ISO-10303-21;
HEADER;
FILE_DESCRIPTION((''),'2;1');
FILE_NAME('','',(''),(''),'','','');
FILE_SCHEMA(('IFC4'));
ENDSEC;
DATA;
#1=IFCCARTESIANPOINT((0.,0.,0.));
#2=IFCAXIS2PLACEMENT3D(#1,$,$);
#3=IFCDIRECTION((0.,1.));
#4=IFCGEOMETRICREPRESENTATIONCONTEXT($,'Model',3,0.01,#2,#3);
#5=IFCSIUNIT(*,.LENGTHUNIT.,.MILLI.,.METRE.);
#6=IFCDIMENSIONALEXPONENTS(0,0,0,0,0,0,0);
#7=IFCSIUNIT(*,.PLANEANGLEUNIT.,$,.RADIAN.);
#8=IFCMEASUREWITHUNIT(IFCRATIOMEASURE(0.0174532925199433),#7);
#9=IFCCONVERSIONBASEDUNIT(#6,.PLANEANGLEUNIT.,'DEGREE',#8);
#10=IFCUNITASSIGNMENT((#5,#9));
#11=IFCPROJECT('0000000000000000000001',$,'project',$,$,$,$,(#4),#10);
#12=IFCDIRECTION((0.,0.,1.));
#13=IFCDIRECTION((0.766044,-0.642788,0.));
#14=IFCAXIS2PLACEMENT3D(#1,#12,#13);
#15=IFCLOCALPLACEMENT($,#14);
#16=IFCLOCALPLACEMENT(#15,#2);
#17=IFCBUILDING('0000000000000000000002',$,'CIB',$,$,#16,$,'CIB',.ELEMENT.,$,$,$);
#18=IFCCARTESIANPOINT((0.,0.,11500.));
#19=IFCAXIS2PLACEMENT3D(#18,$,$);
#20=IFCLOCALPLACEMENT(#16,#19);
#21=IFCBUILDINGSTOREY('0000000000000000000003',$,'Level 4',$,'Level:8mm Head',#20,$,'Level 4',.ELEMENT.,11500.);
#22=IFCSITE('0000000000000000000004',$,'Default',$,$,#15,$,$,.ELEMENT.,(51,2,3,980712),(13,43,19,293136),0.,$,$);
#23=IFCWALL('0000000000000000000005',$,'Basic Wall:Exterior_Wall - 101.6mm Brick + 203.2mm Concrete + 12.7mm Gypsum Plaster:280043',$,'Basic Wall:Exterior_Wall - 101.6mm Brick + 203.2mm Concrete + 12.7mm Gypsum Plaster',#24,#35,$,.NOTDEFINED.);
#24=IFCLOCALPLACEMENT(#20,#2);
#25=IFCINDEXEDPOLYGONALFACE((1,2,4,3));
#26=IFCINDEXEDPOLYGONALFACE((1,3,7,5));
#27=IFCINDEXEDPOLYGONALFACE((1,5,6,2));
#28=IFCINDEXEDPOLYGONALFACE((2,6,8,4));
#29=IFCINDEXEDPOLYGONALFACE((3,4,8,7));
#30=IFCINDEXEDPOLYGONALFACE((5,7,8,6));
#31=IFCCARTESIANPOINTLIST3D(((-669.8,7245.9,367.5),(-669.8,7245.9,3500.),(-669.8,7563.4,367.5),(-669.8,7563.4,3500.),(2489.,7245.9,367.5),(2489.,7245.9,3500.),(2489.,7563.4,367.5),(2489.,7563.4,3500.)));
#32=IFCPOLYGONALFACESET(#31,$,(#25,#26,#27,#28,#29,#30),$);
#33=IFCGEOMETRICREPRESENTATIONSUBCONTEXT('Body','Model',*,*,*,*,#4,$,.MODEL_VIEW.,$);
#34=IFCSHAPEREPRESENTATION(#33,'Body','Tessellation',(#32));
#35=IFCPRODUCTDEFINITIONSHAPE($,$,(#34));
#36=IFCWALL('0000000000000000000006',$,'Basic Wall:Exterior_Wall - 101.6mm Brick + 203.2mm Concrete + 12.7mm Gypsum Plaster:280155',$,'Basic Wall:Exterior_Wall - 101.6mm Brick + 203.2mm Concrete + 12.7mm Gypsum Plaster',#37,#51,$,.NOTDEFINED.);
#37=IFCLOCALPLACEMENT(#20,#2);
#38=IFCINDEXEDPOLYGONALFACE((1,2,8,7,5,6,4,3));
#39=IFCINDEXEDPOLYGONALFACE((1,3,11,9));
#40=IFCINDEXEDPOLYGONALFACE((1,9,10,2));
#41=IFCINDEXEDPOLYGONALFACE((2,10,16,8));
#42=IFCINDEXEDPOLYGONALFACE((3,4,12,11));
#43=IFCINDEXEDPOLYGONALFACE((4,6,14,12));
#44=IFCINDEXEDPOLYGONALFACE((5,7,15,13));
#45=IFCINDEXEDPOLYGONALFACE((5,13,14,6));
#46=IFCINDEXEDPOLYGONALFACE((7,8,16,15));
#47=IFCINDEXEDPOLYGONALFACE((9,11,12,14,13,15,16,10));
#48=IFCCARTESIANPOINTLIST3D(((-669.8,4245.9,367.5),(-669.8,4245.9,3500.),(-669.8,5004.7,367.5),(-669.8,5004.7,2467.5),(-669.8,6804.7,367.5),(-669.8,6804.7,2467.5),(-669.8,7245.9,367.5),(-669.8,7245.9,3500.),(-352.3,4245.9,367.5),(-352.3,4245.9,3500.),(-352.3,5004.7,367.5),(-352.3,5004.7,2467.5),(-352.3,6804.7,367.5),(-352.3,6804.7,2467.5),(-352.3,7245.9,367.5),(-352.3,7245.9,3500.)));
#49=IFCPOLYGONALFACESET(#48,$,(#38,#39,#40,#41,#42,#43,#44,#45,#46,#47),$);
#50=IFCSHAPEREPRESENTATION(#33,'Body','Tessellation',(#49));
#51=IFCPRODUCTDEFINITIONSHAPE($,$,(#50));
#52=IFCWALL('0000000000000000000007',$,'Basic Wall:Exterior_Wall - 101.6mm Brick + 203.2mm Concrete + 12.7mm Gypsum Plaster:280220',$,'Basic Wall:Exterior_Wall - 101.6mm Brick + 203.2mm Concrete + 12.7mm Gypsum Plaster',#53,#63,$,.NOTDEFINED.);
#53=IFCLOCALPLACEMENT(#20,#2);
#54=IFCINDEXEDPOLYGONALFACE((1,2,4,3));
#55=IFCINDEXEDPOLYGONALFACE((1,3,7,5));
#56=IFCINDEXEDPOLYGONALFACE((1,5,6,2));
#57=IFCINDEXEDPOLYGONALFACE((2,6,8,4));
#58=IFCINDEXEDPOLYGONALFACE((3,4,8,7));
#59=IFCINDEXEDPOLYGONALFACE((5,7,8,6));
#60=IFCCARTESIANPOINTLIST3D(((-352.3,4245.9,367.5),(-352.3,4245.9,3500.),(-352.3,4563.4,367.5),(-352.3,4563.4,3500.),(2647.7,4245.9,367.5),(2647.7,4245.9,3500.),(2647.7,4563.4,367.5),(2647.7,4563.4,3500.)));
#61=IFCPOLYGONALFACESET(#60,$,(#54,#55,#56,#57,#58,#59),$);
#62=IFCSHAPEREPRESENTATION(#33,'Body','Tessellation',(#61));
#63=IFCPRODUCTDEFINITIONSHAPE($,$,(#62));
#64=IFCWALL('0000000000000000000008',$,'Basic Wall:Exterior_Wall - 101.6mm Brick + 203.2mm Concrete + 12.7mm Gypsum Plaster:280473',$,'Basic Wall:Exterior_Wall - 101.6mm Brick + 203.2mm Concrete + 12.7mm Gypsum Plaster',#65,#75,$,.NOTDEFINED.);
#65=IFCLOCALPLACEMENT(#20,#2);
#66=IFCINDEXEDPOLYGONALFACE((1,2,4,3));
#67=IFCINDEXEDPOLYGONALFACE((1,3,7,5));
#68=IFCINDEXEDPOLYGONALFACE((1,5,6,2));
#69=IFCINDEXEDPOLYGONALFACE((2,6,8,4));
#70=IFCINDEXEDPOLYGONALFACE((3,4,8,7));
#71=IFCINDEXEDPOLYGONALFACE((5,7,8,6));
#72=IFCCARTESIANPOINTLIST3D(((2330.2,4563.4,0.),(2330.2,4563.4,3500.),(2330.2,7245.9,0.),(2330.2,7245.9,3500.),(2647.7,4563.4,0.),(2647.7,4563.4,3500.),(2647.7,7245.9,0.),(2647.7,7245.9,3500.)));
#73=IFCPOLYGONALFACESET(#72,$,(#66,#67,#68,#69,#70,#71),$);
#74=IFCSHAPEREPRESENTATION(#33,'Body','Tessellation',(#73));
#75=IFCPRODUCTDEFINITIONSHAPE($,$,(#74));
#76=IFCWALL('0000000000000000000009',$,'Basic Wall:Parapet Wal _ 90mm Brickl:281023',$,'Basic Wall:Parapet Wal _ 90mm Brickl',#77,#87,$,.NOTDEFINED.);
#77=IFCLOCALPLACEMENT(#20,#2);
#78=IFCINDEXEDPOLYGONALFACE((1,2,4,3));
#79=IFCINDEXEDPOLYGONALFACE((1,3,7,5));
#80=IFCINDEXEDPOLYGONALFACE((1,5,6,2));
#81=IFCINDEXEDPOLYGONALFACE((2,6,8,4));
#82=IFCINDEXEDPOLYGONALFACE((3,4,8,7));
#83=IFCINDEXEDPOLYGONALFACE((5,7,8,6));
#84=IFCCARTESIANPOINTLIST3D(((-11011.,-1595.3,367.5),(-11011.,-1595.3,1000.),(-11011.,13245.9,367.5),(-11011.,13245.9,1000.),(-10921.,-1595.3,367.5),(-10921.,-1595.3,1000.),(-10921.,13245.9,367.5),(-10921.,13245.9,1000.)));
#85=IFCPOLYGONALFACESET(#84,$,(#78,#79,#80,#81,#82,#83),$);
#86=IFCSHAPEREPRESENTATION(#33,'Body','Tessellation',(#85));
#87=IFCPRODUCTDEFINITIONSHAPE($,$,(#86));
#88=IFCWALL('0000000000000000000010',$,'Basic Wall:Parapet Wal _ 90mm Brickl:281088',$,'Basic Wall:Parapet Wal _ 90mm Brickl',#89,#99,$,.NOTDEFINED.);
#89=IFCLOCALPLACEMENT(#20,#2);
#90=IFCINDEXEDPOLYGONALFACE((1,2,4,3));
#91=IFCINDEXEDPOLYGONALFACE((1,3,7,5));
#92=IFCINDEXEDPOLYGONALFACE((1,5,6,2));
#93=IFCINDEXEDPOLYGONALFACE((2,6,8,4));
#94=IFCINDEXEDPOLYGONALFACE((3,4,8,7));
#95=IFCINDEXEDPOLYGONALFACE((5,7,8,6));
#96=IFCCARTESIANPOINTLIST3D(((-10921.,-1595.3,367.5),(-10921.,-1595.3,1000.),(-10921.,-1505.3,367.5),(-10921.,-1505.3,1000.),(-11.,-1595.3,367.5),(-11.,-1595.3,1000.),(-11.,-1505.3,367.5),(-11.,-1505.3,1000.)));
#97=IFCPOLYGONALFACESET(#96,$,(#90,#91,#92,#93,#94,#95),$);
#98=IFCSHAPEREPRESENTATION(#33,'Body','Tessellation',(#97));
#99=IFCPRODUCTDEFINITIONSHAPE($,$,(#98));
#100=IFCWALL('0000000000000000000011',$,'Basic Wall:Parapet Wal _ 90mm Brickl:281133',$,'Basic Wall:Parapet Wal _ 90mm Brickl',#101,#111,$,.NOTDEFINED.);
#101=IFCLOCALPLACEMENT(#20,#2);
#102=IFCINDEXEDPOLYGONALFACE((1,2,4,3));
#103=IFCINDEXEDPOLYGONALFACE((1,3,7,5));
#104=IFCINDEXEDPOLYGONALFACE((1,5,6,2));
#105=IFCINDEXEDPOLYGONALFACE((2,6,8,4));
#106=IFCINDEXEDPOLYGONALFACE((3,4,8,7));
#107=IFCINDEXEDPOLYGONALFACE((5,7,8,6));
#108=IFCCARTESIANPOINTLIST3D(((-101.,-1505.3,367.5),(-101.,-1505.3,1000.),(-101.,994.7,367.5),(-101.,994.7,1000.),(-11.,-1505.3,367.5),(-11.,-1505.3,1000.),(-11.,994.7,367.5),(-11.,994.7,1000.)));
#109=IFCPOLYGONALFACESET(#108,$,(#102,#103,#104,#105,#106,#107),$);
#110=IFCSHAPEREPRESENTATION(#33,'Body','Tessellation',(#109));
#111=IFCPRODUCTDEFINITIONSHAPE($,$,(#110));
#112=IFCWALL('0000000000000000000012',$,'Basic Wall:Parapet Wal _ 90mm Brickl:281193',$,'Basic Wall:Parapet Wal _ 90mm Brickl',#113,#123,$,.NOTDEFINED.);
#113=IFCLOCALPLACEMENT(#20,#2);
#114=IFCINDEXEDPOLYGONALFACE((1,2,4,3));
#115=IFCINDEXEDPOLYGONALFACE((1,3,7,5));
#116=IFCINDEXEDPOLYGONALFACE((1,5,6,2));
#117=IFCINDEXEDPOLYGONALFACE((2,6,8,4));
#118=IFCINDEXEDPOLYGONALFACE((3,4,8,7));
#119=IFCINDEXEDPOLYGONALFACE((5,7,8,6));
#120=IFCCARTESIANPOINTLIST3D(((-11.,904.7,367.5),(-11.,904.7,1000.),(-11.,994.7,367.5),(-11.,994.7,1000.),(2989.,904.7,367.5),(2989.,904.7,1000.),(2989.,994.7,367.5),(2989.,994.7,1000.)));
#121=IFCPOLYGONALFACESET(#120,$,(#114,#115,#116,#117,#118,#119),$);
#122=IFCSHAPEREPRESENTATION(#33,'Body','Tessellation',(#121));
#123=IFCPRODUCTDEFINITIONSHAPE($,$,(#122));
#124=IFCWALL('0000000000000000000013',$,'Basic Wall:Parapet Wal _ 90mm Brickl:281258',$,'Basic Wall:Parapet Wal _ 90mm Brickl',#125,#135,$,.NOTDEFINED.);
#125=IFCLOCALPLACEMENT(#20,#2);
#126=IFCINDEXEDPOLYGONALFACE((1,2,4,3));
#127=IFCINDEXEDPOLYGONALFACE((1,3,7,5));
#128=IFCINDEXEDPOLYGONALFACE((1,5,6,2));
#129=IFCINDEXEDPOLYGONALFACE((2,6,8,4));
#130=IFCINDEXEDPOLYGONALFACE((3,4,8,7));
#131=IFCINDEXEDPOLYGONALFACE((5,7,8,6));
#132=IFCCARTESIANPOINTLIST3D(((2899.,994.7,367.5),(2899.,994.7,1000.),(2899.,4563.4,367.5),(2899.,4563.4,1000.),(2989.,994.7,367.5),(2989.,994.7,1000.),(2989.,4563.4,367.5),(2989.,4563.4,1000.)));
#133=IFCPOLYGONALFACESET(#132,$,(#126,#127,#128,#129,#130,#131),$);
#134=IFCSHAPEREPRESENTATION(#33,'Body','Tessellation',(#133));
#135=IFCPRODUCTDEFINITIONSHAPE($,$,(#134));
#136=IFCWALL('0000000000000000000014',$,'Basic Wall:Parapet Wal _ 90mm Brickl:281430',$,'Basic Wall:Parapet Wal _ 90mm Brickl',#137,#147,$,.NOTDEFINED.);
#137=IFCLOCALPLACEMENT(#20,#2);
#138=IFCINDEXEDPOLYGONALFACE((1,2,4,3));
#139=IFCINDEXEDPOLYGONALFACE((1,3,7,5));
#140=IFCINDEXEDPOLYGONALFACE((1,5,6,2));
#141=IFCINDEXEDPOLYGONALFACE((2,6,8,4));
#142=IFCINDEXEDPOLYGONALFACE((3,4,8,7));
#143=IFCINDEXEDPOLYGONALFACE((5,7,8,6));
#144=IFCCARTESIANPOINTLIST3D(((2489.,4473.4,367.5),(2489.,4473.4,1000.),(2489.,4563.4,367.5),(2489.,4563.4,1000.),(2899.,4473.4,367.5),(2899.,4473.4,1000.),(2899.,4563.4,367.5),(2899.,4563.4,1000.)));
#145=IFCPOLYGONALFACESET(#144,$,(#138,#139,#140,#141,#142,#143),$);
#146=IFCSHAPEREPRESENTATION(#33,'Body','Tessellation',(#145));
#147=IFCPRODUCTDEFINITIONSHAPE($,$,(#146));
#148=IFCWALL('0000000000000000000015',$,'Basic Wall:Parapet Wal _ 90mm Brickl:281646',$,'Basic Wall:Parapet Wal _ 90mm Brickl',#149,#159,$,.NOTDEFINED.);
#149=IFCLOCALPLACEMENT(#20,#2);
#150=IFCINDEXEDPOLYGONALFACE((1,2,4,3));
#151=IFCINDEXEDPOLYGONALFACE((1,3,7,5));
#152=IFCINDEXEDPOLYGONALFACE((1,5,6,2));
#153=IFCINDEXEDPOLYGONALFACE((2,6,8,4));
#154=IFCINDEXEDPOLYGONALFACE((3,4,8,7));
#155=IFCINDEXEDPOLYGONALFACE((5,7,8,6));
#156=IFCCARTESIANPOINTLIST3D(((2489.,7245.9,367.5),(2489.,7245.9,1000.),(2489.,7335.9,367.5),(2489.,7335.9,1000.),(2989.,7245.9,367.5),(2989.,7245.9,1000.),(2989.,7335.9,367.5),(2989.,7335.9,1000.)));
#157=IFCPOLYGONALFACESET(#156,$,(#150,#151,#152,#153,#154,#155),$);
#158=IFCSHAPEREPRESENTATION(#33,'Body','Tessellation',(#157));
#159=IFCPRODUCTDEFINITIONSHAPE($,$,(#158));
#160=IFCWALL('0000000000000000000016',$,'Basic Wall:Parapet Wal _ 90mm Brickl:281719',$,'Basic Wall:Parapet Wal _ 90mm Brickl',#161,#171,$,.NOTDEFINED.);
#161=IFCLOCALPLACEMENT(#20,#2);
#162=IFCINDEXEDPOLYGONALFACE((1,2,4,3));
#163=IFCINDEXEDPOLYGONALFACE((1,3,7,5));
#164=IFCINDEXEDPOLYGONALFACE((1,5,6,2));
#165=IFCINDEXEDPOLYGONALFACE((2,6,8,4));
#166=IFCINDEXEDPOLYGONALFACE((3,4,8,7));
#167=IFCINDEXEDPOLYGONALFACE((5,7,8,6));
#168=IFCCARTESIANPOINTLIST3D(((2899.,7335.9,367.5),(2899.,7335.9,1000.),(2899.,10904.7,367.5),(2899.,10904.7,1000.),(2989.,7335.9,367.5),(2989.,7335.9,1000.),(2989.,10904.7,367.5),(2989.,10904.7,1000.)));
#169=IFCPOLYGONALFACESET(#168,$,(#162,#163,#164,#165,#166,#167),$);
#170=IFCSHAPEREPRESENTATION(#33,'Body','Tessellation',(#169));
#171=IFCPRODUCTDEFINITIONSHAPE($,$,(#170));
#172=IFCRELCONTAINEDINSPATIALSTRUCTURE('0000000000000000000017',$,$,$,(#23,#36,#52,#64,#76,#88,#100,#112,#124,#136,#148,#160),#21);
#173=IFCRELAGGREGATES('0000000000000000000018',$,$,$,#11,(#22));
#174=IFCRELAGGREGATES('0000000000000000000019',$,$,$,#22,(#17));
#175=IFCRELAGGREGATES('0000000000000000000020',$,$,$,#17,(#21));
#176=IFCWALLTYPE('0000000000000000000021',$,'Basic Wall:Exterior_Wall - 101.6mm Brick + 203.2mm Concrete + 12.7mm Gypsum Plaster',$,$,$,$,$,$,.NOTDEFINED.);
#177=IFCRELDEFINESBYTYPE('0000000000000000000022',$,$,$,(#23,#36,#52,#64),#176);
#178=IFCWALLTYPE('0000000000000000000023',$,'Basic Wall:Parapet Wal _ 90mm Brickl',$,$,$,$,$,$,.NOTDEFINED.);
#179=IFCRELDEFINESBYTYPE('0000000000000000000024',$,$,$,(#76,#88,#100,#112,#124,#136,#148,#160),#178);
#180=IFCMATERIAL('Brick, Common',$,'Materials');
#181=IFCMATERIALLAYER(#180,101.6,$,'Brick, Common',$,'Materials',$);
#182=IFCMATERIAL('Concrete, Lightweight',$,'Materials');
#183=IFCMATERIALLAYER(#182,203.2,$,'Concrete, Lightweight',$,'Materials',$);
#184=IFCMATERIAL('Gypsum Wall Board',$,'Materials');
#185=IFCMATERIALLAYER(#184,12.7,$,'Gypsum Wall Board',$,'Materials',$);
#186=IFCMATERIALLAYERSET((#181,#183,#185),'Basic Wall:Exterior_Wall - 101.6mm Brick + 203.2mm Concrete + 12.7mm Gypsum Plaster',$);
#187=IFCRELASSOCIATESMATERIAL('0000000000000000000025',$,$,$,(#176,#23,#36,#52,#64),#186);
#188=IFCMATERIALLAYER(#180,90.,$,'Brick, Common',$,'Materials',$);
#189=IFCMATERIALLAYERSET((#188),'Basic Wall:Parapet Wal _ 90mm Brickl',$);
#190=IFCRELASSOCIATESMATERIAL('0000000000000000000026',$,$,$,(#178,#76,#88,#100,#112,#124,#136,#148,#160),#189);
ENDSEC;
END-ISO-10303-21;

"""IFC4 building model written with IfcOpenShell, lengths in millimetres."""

from ifc_helpers import new_model, entity, si_unit, converted_unit, direction, frame, frame_2d, origin, place, context, subcontext, project, spatial, rectangle, extrude, material, layer, layer_set, layer_usage, type_object, element, save


model = new_model("IFC4")

# Units and contexts
model_context = context("Model", 3, precision=0.01, world=origin(), true_north=direction((0.0, 1.0)))
body_context = subcontext(model_context, "Body", "Model", "MODEL_VIEW")
ifc_project = project(units=[si_unit("LENGTHUNIT", "METRE", prefix="MILLI"), converted_unit("PLANEANGLEUNIT", "DEGREE", entity("IfcRatioMeasure", 0.0174532925199433), si_unit("PLANEANGLEUNIT", "RADIAN"), dimensions=[0, 0, 0, 0, 0, 0, 0])], contexts=[model_context])

# Site, building, storey
site_placement = place(None, frame((0.0, 0.0, 0.0), z_axis=(0.0, 0.0, 1.0), x_axis=(0.766044, -0.642788, 0.0)))
site = spatial("IfcSite", under=ifc_project, at=site_placement, Name="Default", CompositionType="ELEMENT", RefLatitude=(51, 2, 3, 980712), RefLongitude=(13, 43, 19, 293136), RefElevation=0.0)
building_placement = place(site_placement, origin())
building = spatial("IfcBuilding", under=site, at=building_placement, Name="CIB", LongName="CIB", CompositionType="ELEMENT")
storey_placement = place(building_placement, frame((0.0, 0.0, 11500.0)))
storey = spatial("IfcBuildingStorey", under=building, at=storey_placement, Name="Level 4", ObjectType="Level:8mm Head", LongName="Level 4", CompositionType="ELEMENT", Elevation=11500.0)

# Wall
ifc_material_1 = material(Name="Brick, Common", Category="Materials")
ifc_layer_1 = layer(ifc_material_1, 101.6, Name="Brick, Common", Category="Materials")
ifc_material_2 = material(Name="Concrete, Lightweight", Category="Materials")
ifc_layer_2 = layer(ifc_material_2, 203.2, Name="Concrete, Lightweight", Category="Materials")
ifc_material_3 = material(Name="Gypsum Wall Board", Category="Materials")
ifc_layer_3 = layer(ifc_material_3, 12.7, Name="Gypsum Wall Board", Category="Materials")
ifc_layer_set_1 = layer_set([ifc_layer_1, ifc_layer_2, ifc_layer_3], Name="Basic Wall:Exterior_Wall - 101.6mm Brick + 203.2mm Concrete + 12.7mm Gypsum Plaster")
ifc_layer_usage_1 = layer_usage(ifc_layer_set_1, "AXIS2", "NEGATIVE", 158.8)
wall_type_1 = type_object("IfcWallType", Name="Basic Wall:Exterior_Wall - 101.6mm Brick + 203.2mm Concrete + 12.7mm Gypsum Plaster", PredefinedType="NOTDEFINED", material=ifc_layer_set_1)
wall_1_placement = place(storey_placement, frame((2647.7, 7404.7, 367.5), z_axis=(0.0, 0.0, 1.0), x_axis=(-1.0, 0.0, 0.0)))
element("IfcWall", 1, at=wall_1_placement, inside=storey, type_object=wall_type_1, material=ifc_layer_usage_1, Name="Basic Wall:Exterior_Wall - 101.6mm Brick + 203.2mm Concrete + 12.7mm Gypsum Plaster:280043", ObjectType="Basic Wall:Exterior_Wall - 101.6mm Brick + 203.2mm Concrete + 12.7mm Gypsum Plaster", PredefinedType="NOTDEFINED", context=body_context, shape_type="SweptSolid", body=[
    extrude(rectangle(XDim=3158.8, YDim=317.5, at=frame_2d((1738.1, 0.0), x_axis=(-1.0, 0.0))), origin(), (0.0, 0.0, 1.0), 3132.5),
])

# Wall, opening
ifc_layer_usage_2 = layer_usage(ifc_layer_set_1, "AXIS2", "NEGATIVE", 158.8)
wall_2_placement = place(storey_placement, frame((-511.0, 7245.9, 367.5), z_axis=(0.0, 0.0, 1.0), x_axis=(0.0, -1.0, 0.0)))
wall_2 = element("IfcWall", 2, at=wall_2_placement, inside=storey, type_object=wall_type_1, material=ifc_layer_usage_2, Name="Basic Wall:Exterior_Wall - 101.6mm Brick + 203.2mm Concrete + 12.7mm Gypsum Plaster:280155", ObjectType="Basic Wall:Exterior_Wall - 101.6mm Brick + 203.2mm Concrete + 12.7mm Gypsum Plaster", PredefinedType="NOTDEFINED", context=body_context, shape_type="SweptSolid", body=[
    extrude(rectangle(XDim=3000.0, YDim=317.5, at=frame_2d((1500.0, 0.0), x_axis=(-1.0, 0.0))), origin(), (0.0, 0.0, 1.0), 3132.5),
])
opening_placement = place(wall_2_placement, frame((2241.2, 158.7, 0.0)))
element("IfcOpeningElement", 3, at=opening_placement, cuts=wall_2, ObjectType="Opening", PredefinedType="OPENING", context=body_context, shape_type="SweptSolid", body=[
    extrude(rectangle(XDim=2100.0, YDim=1800.0, at=frame_2d((1050.0, 900.0), x_axis=(1.0, 0.0))), frame((0.0, 0.0, 0.0), z_axis=(0.0, -1.0, 0.0), x_axis=(0.0, 0.0, 1.0)), (0.0, 0.0, 1.0), 317.5),
])

# Walls
ifc_layer_usage_3 = layer_usage(ifc_layer_set_1, "AXIS2", "NEGATIVE", 158.8)
wall_3_placement = place(storey_placement, frame((-352.3, 4404.7, 367.5)))
element("IfcWall", 4, at=wall_3_placement, inside=storey, type_object=wall_type_1, material=ifc_layer_usage_3, Name="Basic Wall:Exterior_Wall - 101.6mm Brick + 203.2mm Concrete + 12.7mm Gypsum Plaster:280220", ObjectType="Basic Wall:Exterior_Wall - 101.6mm Brick + 203.2mm Concrete + 12.7mm Gypsum Plaster", PredefinedType="NOTDEFINED", context=body_context, shape_type="SweptSolid", body=[
    extrude(rectangle(XDim=3000.0, YDim=317.5, at=frame_2d((1500.0, 0.0), x_axis=(-1.0, 0.0))), origin(), (0.0, 0.0, 1.0), 3132.5),
])
ifc_layer_usage_4 = layer_usage(ifc_layer_set_1, "AXIS2", "NEGATIVE", 158.8)
wall_4_placement = place(storey_placement, frame((2489.0, 7245.9, 0.0), z_axis=(0.0, 0.0, 1.0), x_axis=(0.0, -1.0, 0.0)))
element("IfcWall", 5, at=wall_4_placement, inside=storey, type_object=wall_type_1, material=ifc_layer_usage_4, Name="Basic Wall:Exterior_Wall - 101.6mm Brick + 203.2mm Concrete + 12.7mm Gypsum Plaster:280473", ObjectType="Basic Wall:Exterior_Wall - 101.6mm Brick + 203.2mm Concrete + 12.7mm Gypsum Plaster", PredefinedType="NOTDEFINED", context=body_context, shape_type="SweptSolid", body=[
    extrude(rectangle(XDim=2682.5, YDim=317.5, at=frame_2d((1341.2, 0.0), x_axis=(-1.0, 0.0))), origin(), (0.0, 0.0, 1.0), 3500.0),
])
ifc_layer_4 = layer(ifc_material_1, 90.0, Name="Brick, Common", Category="Materials")
ifc_layer_set_2 = layer_set([ifc_layer_4], Name="Basic Wall:Parapet Wal _ 90mm Brickl")
ifc_layer_usage_5 = layer_usage(ifc_layer_set_2, "AXIS2", "NEGATIVE", 45.0)
wall_type_2 = type_object("IfcWallType", Name="Basic Wall:Parapet Wal _ 90mm Brickl", PredefinedType="NOTDEFINED", material=ifc_layer_set_2)
wall_5_placement = place(storey_placement, frame((-10966.0, 13245.9, 367.5), z_axis=(0.0, 0.0, 1.0), x_axis=(0.0, -1.0, 0.0)))
element("IfcWall", 6, at=wall_5_placement, inside=storey, type_object=wall_type_2, material=ifc_layer_usage_5, Name="Basic Wall:Parapet Wal _ 90mm Brickl:281023", ObjectType="Basic Wall:Parapet Wal _ 90mm Brickl", PredefinedType="NOTDEFINED", context=body_context, shape_type="SweptSolid", body=[
    extrude(rectangle(XDim=14841.2, YDim=90.0, at=frame_2d((7420.6, 0.0), x_axis=(-1.0, 0.0))), origin(), (0.0, 0.0, 1.0), 632.5),
])
ifc_layer_usage_6 = layer_usage(ifc_layer_set_2, "AXIS2", "NEGATIVE", 45.0)
wall_6_placement = place(storey_placement, frame((-10921.0, -1550.3, 367.5)))
element("IfcWall", 7, at=wall_6_placement, inside=storey, type_object=wall_type_2, material=ifc_layer_usage_6, Name="Basic Wall:Parapet Wal _ 90mm Brickl:281088", ObjectType="Basic Wall:Parapet Wal _ 90mm Brickl", PredefinedType="NOTDEFINED", context=body_context, shape_type="SweptSolid", body=[
    extrude(rectangle(XDim=10910.0, YDim=90.0, at=frame_2d((5455.0, 0.0), x_axis=(-1.0, 0.0))), origin(), (0.0, 0.0, 1.0), 632.5),
])
ifc_layer_usage_7 = layer_usage(ifc_layer_set_2, "AXIS2", "NEGATIVE", 45.0)
wall_7_placement = place(storey_placement, frame((-56.0, -1505.3, 367.5), z_axis=(0.0, 0.0, 1.0), x_axis=(0.0, 1.0, 0.0)))
element("IfcWall", 8, at=wall_7_placement, inside=storey, type_object=wall_type_2, material=ifc_layer_usage_7, Name="Basic Wall:Parapet Wal _ 90mm Brickl:281133", ObjectType="Basic Wall:Parapet Wal _ 90mm Brickl", PredefinedType="NOTDEFINED", context=body_context, shape_type="SweptSolid", body=[
    extrude(rectangle(XDim=2500.0, YDim=90.0, at=frame_2d((1250.0, 0.0), x_axis=(-1.0, 0.0))), origin(), (0.0, 0.0, 1.0), 632.5),
])
ifc_layer_usage_8 = layer_usage(ifc_layer_set_2, "AXIS2", "NEGATIVE", 45.0)
wall_8_placement = place(storey_placement, frame((-11.0, 949.7, 367.5)))
element("IfcWall", 9, at=wall_8_placement, inside=storey, type_object=wall_type_2, material=ifc_layer_usage_8, Name="Basic Wall:Parapet Wal _ 90mm Brickl:281193", ObjectType="Basic Wall:Parapet Wal _ 90mm Brickl", PredefinedType="NOTDEFINED", context=body_context, shape_type="SweptSolid", body=[
    extrude(rectangle(XDim=3000.0, YDim=90.0, at=frame_2d((1500.0, 0.0), x_axis=(-1.0, 0.0))), origin(), (0.0, 0.0, 1.0), 632.5),
])
ifc_layer_usage_9 = layer_usage(ifc_layer_set_2, "AXIS2", "NEGATIVE", 45.0)
wall_9_placement = place(storey_placement, frame((2944.0, 994.7, 367.5), z_axis=(0.0, 0.0, 1.0), x_axis=(0.0, 1.0, 0.0)))
element("IfcWall", 10, at=wall_9_placement, inside=storey, type_object=wall_type_2, material=ifc_layer_usage_9, Name="Basic Wall:Parapet Wal _ 90mm Brickl:281258", ObjectType="Basic Wall:Parapet Wal _ 90mm Brickl", PredefinedType="NOTDEFINED", context=body_context, shape_type="SweptSolid", body=[
    extrude(rectangle(XDim=3568.8, YDim=90.0, at=frame_2d((1784.4, 0.0), x_axis=(-1.0, 0.0))), origin(), (0.0, 0.0, 1.0), 632.5),
])
ifc_layer_usage_10 = layer_usage(ifc_layer_set_2, "AXIS2", "NEGATIVE", 45.0)
wall_10_placement = place(storey_placement, frame((2899.0, 4518.4, 367.5), z_axis=(0.0, 0.0, 1.0), x_axis=(-1.0, 0.0, 0.0)))
element("IfcWall", 11, at=wall_10_placement, inside=storey, type_object=wall_type_2, material=ifc_layer_usage_10, Name="Basic Wall:Parapet Wal _ 90mm Brickl:281430", ObjectType="Basic Wall:Parapet Wal _ 90mm Brickl", PredefinedType="NOTDEFINED", context=body_context, shape_type="SweptSolid", body=[
    extrude(rectangle(XDim=410.0, YDim=90.0, at=frame_2d((205.0, 0.0), x_axis=(-1.0, 0.0))), origin(), (0.0, 0.0, 1.0), 632.5),
])
ifc_layer_usage_11 = layer_usage(ifc_layer_set_2, "AXIS2", "NEGATIVE", 45.0)
wall_11_placement = place(storey_placement, frame((2489.0, 7290.9, 367.5)))
element("IfcWall", 12, at=wall_11_placement, inside=storey, type_object=wall_type_2, material=ifc_layer_usage_11, Name="Basic Wall:Parapet Wal _ 90mm Brickl:281646", ObjectType="Basic Wall:Parapet Wal _ 90mm Brickl", PredefinedType="NOTDEFINED", context=body_context, shape_type="SweptSolid", body=[
    extrude(rectangle(XDim=500.0, YDim=90.0, at=frame_2d((250.0, 0.0), x_axis=(-1.0, 0.0))), origin(), (0.0, 0.0, 1.0), 632.5),
])
ifc_layer_usage_12 = layer_usage(ifc_layer_set_2, "AXIS2", "NEGATIVE", 45.0)
wall_12_placement = place(storey_placement, frame((2944.0, 7335.9, 367.5), z_axis=(0.0, 0.0, 1.0), x_axis=(0.0, 1.0, 0.0)))
element("IfcWall", 13, at=wall_12_placement, inside=storey, type_object=wall_type_2, material=ifc_layer_usage_12, Name="Basic Wall:Parapet Wal _ 90mm Brickl:281719", ObjectType="Basic Wall:Parapet Wal _ 90mm Brickl", PredefinedType="NOTDEFINED", context=body_context, shape_type="SweptSolid", body=[
    extrude(rectangle(XDim=3568.7, YDim=90.0, at=frame_2d((1784.4, 0.0), x_axis=(-1.0, 0.0))), origin(), (0.0, 0.0, 1.0), 632.5),
])

save(model, "model.ifc")
